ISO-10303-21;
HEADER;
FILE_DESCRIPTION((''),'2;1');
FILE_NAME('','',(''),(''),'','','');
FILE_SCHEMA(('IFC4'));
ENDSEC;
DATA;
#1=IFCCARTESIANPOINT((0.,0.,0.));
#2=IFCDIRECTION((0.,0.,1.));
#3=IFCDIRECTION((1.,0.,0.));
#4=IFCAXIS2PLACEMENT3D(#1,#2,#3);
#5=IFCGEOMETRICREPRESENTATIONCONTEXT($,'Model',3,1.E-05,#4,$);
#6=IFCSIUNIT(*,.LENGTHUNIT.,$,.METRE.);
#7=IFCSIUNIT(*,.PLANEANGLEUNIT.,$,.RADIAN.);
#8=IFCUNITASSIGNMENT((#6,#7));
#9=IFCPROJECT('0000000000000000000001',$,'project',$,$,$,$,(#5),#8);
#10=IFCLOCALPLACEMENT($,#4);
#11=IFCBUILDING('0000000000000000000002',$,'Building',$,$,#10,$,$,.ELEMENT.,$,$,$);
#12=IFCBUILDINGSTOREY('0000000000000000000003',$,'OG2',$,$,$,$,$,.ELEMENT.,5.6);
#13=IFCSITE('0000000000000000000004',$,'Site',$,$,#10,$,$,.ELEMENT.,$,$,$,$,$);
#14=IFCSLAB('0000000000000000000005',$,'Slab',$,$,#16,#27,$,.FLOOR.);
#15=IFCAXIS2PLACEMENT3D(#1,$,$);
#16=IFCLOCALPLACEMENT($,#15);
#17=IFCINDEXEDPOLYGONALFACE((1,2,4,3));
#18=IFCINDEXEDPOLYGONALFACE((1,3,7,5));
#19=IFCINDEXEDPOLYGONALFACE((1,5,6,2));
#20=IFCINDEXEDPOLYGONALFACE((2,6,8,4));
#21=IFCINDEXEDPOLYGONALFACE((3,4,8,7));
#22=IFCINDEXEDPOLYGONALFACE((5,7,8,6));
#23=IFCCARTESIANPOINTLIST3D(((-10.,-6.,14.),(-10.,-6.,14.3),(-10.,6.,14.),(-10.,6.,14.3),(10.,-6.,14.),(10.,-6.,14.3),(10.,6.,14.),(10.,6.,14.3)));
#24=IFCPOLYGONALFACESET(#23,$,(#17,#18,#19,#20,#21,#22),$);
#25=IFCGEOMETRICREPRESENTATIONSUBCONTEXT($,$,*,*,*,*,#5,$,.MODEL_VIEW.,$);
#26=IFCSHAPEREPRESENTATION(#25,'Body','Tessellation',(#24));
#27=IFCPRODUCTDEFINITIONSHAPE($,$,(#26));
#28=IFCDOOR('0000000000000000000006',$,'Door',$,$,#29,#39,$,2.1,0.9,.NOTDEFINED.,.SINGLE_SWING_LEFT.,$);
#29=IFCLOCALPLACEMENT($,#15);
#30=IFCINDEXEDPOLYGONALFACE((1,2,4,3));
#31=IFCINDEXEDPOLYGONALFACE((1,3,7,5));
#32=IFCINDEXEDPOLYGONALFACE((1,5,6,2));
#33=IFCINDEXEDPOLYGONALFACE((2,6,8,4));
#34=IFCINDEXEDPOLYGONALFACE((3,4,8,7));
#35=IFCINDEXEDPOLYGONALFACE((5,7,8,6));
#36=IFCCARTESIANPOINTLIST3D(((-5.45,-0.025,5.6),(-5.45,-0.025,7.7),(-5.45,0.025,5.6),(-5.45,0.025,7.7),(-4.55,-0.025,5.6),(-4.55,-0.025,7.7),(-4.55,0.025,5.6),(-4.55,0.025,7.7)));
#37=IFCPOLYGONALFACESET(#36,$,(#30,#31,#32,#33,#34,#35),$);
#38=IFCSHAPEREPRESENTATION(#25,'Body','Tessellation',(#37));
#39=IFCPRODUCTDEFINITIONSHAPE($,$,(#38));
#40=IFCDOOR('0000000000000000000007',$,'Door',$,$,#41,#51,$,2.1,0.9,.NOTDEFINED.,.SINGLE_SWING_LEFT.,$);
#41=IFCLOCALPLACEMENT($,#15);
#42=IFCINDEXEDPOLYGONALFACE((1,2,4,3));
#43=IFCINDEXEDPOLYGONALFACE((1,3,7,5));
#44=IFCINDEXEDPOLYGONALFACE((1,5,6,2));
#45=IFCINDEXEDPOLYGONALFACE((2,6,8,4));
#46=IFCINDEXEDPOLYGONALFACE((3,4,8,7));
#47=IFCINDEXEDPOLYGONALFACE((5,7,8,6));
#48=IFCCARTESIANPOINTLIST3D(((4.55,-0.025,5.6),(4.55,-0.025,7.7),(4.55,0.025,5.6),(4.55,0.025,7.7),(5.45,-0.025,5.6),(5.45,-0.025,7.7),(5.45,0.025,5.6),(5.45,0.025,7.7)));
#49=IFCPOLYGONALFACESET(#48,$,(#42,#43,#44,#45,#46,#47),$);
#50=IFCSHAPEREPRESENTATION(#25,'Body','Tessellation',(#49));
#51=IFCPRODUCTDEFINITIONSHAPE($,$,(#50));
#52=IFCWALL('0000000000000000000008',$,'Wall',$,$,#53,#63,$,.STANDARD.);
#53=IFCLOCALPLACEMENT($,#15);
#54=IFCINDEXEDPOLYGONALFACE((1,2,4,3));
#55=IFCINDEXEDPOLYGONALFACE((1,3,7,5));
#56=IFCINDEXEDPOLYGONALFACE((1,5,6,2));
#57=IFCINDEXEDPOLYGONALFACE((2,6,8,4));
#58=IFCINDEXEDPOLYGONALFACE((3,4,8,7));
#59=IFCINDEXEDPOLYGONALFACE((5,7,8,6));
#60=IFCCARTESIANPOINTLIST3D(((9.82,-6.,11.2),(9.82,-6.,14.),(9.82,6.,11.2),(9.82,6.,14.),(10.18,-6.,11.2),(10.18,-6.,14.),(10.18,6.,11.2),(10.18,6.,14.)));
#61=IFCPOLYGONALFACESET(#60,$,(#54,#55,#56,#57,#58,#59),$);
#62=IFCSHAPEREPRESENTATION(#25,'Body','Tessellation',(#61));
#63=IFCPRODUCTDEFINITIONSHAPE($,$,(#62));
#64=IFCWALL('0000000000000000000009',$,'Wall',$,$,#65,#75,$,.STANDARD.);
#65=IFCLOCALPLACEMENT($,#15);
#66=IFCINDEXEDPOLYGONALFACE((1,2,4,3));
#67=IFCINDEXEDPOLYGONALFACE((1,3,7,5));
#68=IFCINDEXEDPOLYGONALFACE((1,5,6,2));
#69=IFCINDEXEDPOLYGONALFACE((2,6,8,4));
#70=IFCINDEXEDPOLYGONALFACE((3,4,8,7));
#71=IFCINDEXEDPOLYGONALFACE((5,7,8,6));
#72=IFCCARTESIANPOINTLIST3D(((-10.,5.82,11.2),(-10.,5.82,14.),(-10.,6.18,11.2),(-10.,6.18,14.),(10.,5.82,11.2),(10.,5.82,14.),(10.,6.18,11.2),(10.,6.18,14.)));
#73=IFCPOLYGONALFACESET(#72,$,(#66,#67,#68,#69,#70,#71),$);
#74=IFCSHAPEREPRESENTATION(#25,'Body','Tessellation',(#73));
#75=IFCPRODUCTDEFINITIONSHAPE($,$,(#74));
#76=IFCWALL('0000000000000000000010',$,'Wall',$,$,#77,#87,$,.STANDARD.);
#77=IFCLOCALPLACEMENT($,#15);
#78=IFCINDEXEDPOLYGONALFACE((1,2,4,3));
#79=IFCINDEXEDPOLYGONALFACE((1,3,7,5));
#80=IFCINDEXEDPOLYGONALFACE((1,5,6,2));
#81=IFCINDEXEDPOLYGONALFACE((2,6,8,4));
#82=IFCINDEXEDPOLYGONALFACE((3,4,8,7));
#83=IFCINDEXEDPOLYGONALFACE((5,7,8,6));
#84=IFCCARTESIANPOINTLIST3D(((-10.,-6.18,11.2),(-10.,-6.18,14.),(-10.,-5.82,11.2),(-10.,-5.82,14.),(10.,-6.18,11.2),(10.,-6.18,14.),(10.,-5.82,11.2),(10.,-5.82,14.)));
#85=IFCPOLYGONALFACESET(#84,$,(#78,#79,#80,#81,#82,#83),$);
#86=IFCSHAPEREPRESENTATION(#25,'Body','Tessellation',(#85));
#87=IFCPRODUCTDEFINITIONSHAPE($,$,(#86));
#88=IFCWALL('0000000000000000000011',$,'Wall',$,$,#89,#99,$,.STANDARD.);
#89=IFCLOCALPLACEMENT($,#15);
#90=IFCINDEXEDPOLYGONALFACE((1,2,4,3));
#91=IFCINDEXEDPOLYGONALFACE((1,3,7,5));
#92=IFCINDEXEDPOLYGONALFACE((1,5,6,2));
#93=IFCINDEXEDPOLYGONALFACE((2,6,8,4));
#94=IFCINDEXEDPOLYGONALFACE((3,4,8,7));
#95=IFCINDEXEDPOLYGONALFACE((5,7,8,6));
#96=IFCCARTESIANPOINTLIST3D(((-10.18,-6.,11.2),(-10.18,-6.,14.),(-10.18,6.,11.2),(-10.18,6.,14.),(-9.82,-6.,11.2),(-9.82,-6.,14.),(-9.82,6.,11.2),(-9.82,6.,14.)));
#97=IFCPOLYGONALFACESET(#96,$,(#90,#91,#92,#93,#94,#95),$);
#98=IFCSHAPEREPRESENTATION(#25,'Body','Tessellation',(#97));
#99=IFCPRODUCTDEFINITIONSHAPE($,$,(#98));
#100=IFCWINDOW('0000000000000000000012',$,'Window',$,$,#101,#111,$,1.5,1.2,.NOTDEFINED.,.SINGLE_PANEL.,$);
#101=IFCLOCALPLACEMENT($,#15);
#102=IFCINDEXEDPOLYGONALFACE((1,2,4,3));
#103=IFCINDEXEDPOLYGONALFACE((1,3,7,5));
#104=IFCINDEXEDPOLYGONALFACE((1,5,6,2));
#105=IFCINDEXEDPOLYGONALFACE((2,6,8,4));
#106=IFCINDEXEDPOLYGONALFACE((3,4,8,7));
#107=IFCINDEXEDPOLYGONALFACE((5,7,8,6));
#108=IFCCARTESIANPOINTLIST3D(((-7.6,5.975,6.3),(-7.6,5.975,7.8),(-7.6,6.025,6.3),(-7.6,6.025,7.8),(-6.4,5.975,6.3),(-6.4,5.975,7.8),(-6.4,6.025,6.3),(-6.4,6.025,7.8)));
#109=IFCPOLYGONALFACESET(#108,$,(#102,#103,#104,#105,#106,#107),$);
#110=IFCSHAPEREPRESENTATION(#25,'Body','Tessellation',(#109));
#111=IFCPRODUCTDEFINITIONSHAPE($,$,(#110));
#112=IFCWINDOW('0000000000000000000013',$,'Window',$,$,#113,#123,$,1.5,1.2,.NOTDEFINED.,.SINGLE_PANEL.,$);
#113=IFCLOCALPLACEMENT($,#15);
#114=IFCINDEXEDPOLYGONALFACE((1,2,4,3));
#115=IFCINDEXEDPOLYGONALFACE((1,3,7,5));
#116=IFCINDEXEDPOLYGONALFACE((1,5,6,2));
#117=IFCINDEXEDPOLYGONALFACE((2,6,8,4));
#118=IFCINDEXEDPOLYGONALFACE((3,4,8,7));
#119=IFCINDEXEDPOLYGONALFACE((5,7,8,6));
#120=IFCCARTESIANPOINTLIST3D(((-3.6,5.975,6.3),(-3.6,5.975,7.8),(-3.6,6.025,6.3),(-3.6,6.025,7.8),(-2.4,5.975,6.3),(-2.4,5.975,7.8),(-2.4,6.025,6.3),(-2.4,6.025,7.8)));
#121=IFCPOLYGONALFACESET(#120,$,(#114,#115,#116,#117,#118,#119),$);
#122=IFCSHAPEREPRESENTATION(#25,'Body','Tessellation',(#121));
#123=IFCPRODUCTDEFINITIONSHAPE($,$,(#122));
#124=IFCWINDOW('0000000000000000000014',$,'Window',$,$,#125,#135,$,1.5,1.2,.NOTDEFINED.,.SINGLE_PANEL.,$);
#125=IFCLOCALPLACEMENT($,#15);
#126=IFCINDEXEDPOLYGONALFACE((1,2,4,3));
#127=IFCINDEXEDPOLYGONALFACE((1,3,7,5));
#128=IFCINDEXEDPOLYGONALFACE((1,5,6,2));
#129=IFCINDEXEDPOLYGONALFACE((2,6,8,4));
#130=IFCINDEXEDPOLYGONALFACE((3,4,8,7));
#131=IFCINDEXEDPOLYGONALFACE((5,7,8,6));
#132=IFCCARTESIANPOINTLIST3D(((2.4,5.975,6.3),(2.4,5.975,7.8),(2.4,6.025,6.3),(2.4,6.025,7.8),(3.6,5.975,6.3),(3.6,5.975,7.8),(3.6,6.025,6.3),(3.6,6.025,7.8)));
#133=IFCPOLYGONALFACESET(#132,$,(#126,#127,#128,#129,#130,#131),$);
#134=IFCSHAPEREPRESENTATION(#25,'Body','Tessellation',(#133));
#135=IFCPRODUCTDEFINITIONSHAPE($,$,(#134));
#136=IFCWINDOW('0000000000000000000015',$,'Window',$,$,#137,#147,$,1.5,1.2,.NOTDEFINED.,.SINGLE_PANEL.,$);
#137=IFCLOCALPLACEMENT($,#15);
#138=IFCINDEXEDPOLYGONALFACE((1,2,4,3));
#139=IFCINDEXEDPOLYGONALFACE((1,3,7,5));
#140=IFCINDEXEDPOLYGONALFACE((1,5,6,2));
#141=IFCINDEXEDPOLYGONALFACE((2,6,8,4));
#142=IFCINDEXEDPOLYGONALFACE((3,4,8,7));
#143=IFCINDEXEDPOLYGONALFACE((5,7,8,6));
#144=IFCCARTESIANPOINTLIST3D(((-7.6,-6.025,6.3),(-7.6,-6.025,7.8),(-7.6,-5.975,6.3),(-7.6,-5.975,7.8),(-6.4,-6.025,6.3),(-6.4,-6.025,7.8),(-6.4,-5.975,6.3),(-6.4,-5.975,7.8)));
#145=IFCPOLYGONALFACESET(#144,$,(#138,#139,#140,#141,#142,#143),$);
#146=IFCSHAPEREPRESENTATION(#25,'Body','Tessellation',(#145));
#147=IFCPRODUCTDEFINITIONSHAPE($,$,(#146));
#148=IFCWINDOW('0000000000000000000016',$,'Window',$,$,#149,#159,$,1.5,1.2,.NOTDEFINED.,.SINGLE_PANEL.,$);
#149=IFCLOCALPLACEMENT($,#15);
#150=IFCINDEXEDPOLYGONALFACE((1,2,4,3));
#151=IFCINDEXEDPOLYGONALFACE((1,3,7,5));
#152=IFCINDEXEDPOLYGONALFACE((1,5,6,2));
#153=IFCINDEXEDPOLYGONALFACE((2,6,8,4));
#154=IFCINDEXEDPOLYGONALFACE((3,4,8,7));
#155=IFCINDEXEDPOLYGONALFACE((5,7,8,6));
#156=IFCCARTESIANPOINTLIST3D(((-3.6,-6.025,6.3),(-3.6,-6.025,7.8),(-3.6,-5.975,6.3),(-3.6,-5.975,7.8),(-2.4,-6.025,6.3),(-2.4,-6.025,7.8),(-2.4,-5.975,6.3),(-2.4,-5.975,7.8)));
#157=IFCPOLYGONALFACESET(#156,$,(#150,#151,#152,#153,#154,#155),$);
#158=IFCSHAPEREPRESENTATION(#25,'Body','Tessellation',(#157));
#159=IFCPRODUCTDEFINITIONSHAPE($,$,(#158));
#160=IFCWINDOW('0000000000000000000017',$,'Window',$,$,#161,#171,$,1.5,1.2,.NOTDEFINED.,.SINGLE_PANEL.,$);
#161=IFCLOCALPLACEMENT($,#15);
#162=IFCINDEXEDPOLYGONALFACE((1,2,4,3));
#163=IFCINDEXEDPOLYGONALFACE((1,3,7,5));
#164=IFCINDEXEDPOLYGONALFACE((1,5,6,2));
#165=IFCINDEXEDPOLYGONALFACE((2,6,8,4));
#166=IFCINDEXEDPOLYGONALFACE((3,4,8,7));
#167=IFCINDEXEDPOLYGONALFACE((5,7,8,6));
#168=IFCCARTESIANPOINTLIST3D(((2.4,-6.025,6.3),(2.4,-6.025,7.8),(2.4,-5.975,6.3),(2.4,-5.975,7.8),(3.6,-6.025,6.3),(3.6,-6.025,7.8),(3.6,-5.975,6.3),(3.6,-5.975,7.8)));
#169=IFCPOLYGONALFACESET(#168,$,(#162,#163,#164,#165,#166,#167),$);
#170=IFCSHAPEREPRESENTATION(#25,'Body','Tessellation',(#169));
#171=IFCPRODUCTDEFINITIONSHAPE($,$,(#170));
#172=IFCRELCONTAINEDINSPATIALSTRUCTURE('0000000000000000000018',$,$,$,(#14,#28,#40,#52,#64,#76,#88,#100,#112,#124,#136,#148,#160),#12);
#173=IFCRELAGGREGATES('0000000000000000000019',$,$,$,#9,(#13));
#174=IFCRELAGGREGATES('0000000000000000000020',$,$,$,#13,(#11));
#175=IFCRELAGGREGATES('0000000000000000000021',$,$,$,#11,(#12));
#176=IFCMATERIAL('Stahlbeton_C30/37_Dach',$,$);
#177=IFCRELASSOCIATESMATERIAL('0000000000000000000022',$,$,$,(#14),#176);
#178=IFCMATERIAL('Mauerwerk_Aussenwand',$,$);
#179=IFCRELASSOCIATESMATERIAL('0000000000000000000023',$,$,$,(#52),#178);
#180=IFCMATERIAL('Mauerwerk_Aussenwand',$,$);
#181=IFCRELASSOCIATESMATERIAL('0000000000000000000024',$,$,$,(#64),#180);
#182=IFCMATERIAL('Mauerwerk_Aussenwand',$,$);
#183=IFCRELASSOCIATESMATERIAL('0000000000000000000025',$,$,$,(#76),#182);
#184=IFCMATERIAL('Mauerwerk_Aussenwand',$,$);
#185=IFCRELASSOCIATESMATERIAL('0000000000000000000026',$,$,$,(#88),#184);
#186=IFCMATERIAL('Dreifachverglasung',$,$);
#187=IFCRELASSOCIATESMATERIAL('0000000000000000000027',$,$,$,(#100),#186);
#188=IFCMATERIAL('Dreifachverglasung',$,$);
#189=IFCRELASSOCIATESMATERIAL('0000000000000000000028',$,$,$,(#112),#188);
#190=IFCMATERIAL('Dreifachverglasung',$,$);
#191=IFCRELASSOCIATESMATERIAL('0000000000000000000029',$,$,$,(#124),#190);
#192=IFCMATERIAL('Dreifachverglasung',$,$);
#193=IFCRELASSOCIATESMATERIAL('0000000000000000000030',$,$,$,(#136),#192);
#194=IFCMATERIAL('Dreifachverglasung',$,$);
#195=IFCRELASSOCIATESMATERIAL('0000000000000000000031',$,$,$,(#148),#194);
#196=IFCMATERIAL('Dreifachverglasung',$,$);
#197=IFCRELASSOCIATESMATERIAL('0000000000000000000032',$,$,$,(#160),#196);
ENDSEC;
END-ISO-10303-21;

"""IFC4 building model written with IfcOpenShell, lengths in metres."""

from ifc_helpers import new_model, si_unit, frame, frame_2d, origin, origin_with_axes, origin_2d, place, context, subcontext, project, spatial, rectangle, extrude, material, element, save


model = new_model("IFC4")

# Units and contexts
model_context = context("Model", 3, precision=1e-05, world=origin_with_axes())
sub_context = subcontext(model_context, None, None, "MODEL_VIEW")
ifc_project = project(units=[si_unit("LENGTHUNIT", "METRE"), si_unit("PLANEANGLEUNIT", "RADIAN")], contexts=[model_context])

# Site, building, storey
placement_1 = place(None, origin_with_axes())
site = spatial("IfcSite", under=ifc_project, at=placement_1, Name="Site", CompositionType="ELEMENT")
building = spatial("IfcBuilding", under=site, at=placement_1, Name="Building", CompositionType="ELEMENT")
storey = spatial("IfcBuildingStorey", under=building, Name="OG2", CompositionType="ELEMENT", Elevation=5.6)

# Slab
ifc_material_1 = material(Name="Stahlbeton_C30/37_Dach")
placement_2 = place(None, origin_with_axes())
placement_3 = place(placement_2, frame((0.0, 0.0, 5.6)))
slab_placement = place(placement_3, frame((-10.0, -6.0, 8.4)))
element("IfcSlab", 1, at=slab_placement, inside=storey, material=ifc_material_1, Name="Slab", PredefinedType="FLOOR", context=sub_context, shape_type="SweptSolid", body=[
    extrude(rectangle(XDim=20.0, YDim=12.0, at=frame_2d((10.0, 6.0))), origin(), (0.0, 0.0, 1.0), 0.3),
])

# Doors
placement_4 = place(None, origin_with_axes())
door_1_placement = place(placement_4, frame((-5.0, 0.0, 5.6)))
element("IfcDoor", 2, at=door_1_placement, inside=storey, Name="Door", OperationType="SINGLE_SWING_LEFT", OverallHeight=2.1, OverallWidth=0.9, PredefinedType="NOTDEFINED", context=sub_context, shape_type="SweptSolid", body=[
    extrude(rectangle(XDim=0.9, YDim=0.05, at=origin_2d()), origin(), (0.0, 0.0, 1.0), 2.1),
])
placement_5 = place(None, origin_with_axes())
door_2_placement = place(placement_5, frame((5.0, 0.0, 5.6)))
element("IfcDoor", 3, at=door_2_placement, inside=storey, Name="Door", OperationType="SINGLE_SWING_LEFT", OverallHeight=2.1, OverallWidth=0.9, PredefinedType="NOTDEFINED", context=sub_context, shape_type="SweptSolid", body=[
    extrude(rectangle(XDim=0.9, YDim=0.05, at=origin_2d()), origin(), (0.0, 0.0, 1.0), 2.1),
])

# Walls
ifc_material_2 = material(Name="Mauerwerk_Aussenwand")
placement_6 = place(None, origin_with_axes())
placement_7 = place(placement_6, frame((0.0, 0.0, 5.6)))
wall_1_placement = place(placement_7, frame((10.0, -6.0, 5.6), x_axis=(0.0, 1.0, 0.0)))
element("IfcWall", 4, at=wall_1_placement, inside=storey, material=ifc_material_2, Name="Wall", PredefinedType="STANDARD", context=sub_context, shape_type="SweptSolid", body=[
    extrude(rectangle(XDim=12.0, YDim=0.36, at=frame_2d((6.0, 0.0))), origin(), (0.0, 0.0, 1.0), 2.8),
])
ifc_material_3 = material(Name="Mauerwerk_Aussenwand")
placement_8 = place(None, origin_with_axes())
placement_9 = place(placement_8, frame((0.0, 0.0, 5.6)))
wall_2_placement = place(placement_9, frame((-10.0, 6.0, 5.6), x_axis=(1.0, 0.0, 0.0)))
element("IfcWall", 5, at=wall_2_placement, inside=storey, material=ifc_material_3, Name="Wall", PredefinedType="STANDARD", context=sub_context, shape_type="SweptSolid", body=[
    extrude(rectangle(XDim=20.0, YDim=0.36, at=frame_2d((10.0, 0.0))), origin(), (0.0, 0.0, 1.0), 2.8),
])
ifc_material_4 = material(Name="Mauerwerk_Aussenwand")
placement_10 = place(None, origin_with_axes())
placement_11 = place(placement_10, frame((0.0, 0.0, 5.6)))
wall_3_placement = place(placement_11, frame((-10.0, -6.0, 5.6), x_axis=(1.0, 0.0, 0.0)))
element("IfcWall", 6, at=wall_3_placement, inside=storey, material=ifc_material_4, Name="Wall", PredefinedType="STANDARD", context=sub_context, shape_type="SweptSolid", body=[
    extrude(rectangle(XDim=20.0, YDim=0.36, at=frame_2d((10.0, 0.0))), origin(), (0.0, 0.0, 1.0), 2.8),
])
ifc_material_5 = material(Name="Mauerwerk_Aussenwand")
placement_12 = place(None, origin_with_axes())
placement_13 = place(placement_12, frame((0.0, 0.0, 5.6)))
wall_4_placement = place(placement_13, frame((-10.0, -6.0, 5.6), x_axis=(0.0, 1.0, 0.0)))
element("IfcWall", 7, at=wall_4_placement, inside=storey, material=ifc_material_5, Name="Wall", PredefinedType="STANDARD", context=sub_context, shape_type="SweptSolid", body=[
    extrude(rectangle(XDim=12.0, YDim=0.36, at=frame_2d((6.0, 0.0))), origin(), (0.0, 0.0, 1.0), 2.8),
])

# Windows
ifc_material_6 = material(Name="Dreifachverglasung")
placement_14 = place(None, origin_with_axes())
window_1_placement = place(placement_14, frame((-7.0, 6.0, 6.3)))
element("IfcWindow", 8, at=window_1_placement, inside=storey, material=ifc_material_6, Name="Window", OverallHeight=1.5, OverallWidth=1.2, PartitioningType="SINGLE_PANEL", PredefinedType="NOTDEFINED", context=sub_context, shape_type="SweptSolid", body=[
    extrude(rectangle(XDim=1.2, YDim=0.05, at=origin_2d()), origin(), (0.0, 0.0, 1.0), 1.5),
])
ifc_material_7 = material(Name="Dreifachverglasung")
placement_15 = place(None, origin_with_axes())
window_2_placement = place(placement_15, frame((-3.0, 6.0, 6.3)))
element("IfcWindow", 9, at=window_2_placement, inside=storey, material=ifc_material_7, Name="Window", OverallHeight=1.5, OverallWidth=1.2, PartitioningType="SINGLE_PANEL", PredefinedType="NOTDEFINED", context=sub_context, shape_type="SweptSolid", body=[
    extrude(rectangle(XDim=1.2, YDim=0.05, at=origin_2d()), origin(), (0.0, 0.0, 1.0), 1.5),
])
ifc_material_8 = material(Name="Dreifachverglasung")
placement_16 = place(None, origin_with_axes())
window_3_placement = place(placement_16, frame((3.0, 6.0, 6.3)))
element("IfcWindow", 10, at=window_3_placement, inside=storey, material=ifc_material_8, Name="Window", OverallHeight=1.5, OverallWidth=1.2, PartitioningType="SINGLE_PANEL", PredefinedType="NOTDEFINED", context=sub_context, shape_type="SweptSolid", body=[
    extrude(rectangle(XDim=1.2, YDim=0.05, at=origin_2d()), origin(), (0.0, 0.0, 1.0), 1.5),
])
ifc_material_9 = material(Name="Dreifachverglasung")
placement_17 = place(None, origin_with_axes())
window_4_placement = place(placement_17, frame((-7.0, -6.0, 6.3)))
element("IfcWindow", 11, at=window_4_placement, inside=storey, material=ifc_material_9, Name="Window", OverallHeight=1.5, OverallWidth=1.2, PartitioningType="SINGLE_PANEL", PredefinedType="NOTDEFINED", context=sub_context, shape_type="SweptSolid", body=[
    extrude(rectangle(XDim=1.2, YDim=0.05, at=origin_2d()), origin(), (0.0, 0.0, 1.0), 1.5),
])
ifc_material_10 = material(Name="Dreifachverglasung")
placement_18 = place(None, origin_with_axes())
window_5_placement = place(placement_18, frame((-3.0, -6.0, 6.3)))
element("IfcWindow", 12, at=window_5_placement, inside=storey, material=ifc_material_10, Name="Window", OverallHeight=1.5, OverallWidth=1.2, PartitioningType="SINGLE_PANEL", PredefinedType="NOTDEFINED", context=sub_context, shape_type="SweptSolid", body=[
    extrude(rectangle(XDim=1.2, YDim=0.05, at=origin_2d()), origin(), (0.0, 0.0, 1.0), 1.5),
])
ifc_material_11 = material(Name="Dreifachverglasung")
placement_19 = place(None, origin_with_axes())
window_6_placement = place(placement_19, frame((3.0, -6.0, 6.3)))
element("IfcWindow", 13, at=window_6_placement, inside=storey, material=ifc_material_11, Name="Window", OverallHeight=1.5, OverallWidth=1.2, PartitioningType="SINGLE_PANEL", PredefinedType="NOTDEFINED", context=sub_context, shape_type="SweptSolid", body=[
    extrude(rectangle(XDim=1.2, YDim=0.05, at=origin_2d()), origin(), (0.0, 0.0, 1.0), 1.5),
])

save(model, "model.ifc")
